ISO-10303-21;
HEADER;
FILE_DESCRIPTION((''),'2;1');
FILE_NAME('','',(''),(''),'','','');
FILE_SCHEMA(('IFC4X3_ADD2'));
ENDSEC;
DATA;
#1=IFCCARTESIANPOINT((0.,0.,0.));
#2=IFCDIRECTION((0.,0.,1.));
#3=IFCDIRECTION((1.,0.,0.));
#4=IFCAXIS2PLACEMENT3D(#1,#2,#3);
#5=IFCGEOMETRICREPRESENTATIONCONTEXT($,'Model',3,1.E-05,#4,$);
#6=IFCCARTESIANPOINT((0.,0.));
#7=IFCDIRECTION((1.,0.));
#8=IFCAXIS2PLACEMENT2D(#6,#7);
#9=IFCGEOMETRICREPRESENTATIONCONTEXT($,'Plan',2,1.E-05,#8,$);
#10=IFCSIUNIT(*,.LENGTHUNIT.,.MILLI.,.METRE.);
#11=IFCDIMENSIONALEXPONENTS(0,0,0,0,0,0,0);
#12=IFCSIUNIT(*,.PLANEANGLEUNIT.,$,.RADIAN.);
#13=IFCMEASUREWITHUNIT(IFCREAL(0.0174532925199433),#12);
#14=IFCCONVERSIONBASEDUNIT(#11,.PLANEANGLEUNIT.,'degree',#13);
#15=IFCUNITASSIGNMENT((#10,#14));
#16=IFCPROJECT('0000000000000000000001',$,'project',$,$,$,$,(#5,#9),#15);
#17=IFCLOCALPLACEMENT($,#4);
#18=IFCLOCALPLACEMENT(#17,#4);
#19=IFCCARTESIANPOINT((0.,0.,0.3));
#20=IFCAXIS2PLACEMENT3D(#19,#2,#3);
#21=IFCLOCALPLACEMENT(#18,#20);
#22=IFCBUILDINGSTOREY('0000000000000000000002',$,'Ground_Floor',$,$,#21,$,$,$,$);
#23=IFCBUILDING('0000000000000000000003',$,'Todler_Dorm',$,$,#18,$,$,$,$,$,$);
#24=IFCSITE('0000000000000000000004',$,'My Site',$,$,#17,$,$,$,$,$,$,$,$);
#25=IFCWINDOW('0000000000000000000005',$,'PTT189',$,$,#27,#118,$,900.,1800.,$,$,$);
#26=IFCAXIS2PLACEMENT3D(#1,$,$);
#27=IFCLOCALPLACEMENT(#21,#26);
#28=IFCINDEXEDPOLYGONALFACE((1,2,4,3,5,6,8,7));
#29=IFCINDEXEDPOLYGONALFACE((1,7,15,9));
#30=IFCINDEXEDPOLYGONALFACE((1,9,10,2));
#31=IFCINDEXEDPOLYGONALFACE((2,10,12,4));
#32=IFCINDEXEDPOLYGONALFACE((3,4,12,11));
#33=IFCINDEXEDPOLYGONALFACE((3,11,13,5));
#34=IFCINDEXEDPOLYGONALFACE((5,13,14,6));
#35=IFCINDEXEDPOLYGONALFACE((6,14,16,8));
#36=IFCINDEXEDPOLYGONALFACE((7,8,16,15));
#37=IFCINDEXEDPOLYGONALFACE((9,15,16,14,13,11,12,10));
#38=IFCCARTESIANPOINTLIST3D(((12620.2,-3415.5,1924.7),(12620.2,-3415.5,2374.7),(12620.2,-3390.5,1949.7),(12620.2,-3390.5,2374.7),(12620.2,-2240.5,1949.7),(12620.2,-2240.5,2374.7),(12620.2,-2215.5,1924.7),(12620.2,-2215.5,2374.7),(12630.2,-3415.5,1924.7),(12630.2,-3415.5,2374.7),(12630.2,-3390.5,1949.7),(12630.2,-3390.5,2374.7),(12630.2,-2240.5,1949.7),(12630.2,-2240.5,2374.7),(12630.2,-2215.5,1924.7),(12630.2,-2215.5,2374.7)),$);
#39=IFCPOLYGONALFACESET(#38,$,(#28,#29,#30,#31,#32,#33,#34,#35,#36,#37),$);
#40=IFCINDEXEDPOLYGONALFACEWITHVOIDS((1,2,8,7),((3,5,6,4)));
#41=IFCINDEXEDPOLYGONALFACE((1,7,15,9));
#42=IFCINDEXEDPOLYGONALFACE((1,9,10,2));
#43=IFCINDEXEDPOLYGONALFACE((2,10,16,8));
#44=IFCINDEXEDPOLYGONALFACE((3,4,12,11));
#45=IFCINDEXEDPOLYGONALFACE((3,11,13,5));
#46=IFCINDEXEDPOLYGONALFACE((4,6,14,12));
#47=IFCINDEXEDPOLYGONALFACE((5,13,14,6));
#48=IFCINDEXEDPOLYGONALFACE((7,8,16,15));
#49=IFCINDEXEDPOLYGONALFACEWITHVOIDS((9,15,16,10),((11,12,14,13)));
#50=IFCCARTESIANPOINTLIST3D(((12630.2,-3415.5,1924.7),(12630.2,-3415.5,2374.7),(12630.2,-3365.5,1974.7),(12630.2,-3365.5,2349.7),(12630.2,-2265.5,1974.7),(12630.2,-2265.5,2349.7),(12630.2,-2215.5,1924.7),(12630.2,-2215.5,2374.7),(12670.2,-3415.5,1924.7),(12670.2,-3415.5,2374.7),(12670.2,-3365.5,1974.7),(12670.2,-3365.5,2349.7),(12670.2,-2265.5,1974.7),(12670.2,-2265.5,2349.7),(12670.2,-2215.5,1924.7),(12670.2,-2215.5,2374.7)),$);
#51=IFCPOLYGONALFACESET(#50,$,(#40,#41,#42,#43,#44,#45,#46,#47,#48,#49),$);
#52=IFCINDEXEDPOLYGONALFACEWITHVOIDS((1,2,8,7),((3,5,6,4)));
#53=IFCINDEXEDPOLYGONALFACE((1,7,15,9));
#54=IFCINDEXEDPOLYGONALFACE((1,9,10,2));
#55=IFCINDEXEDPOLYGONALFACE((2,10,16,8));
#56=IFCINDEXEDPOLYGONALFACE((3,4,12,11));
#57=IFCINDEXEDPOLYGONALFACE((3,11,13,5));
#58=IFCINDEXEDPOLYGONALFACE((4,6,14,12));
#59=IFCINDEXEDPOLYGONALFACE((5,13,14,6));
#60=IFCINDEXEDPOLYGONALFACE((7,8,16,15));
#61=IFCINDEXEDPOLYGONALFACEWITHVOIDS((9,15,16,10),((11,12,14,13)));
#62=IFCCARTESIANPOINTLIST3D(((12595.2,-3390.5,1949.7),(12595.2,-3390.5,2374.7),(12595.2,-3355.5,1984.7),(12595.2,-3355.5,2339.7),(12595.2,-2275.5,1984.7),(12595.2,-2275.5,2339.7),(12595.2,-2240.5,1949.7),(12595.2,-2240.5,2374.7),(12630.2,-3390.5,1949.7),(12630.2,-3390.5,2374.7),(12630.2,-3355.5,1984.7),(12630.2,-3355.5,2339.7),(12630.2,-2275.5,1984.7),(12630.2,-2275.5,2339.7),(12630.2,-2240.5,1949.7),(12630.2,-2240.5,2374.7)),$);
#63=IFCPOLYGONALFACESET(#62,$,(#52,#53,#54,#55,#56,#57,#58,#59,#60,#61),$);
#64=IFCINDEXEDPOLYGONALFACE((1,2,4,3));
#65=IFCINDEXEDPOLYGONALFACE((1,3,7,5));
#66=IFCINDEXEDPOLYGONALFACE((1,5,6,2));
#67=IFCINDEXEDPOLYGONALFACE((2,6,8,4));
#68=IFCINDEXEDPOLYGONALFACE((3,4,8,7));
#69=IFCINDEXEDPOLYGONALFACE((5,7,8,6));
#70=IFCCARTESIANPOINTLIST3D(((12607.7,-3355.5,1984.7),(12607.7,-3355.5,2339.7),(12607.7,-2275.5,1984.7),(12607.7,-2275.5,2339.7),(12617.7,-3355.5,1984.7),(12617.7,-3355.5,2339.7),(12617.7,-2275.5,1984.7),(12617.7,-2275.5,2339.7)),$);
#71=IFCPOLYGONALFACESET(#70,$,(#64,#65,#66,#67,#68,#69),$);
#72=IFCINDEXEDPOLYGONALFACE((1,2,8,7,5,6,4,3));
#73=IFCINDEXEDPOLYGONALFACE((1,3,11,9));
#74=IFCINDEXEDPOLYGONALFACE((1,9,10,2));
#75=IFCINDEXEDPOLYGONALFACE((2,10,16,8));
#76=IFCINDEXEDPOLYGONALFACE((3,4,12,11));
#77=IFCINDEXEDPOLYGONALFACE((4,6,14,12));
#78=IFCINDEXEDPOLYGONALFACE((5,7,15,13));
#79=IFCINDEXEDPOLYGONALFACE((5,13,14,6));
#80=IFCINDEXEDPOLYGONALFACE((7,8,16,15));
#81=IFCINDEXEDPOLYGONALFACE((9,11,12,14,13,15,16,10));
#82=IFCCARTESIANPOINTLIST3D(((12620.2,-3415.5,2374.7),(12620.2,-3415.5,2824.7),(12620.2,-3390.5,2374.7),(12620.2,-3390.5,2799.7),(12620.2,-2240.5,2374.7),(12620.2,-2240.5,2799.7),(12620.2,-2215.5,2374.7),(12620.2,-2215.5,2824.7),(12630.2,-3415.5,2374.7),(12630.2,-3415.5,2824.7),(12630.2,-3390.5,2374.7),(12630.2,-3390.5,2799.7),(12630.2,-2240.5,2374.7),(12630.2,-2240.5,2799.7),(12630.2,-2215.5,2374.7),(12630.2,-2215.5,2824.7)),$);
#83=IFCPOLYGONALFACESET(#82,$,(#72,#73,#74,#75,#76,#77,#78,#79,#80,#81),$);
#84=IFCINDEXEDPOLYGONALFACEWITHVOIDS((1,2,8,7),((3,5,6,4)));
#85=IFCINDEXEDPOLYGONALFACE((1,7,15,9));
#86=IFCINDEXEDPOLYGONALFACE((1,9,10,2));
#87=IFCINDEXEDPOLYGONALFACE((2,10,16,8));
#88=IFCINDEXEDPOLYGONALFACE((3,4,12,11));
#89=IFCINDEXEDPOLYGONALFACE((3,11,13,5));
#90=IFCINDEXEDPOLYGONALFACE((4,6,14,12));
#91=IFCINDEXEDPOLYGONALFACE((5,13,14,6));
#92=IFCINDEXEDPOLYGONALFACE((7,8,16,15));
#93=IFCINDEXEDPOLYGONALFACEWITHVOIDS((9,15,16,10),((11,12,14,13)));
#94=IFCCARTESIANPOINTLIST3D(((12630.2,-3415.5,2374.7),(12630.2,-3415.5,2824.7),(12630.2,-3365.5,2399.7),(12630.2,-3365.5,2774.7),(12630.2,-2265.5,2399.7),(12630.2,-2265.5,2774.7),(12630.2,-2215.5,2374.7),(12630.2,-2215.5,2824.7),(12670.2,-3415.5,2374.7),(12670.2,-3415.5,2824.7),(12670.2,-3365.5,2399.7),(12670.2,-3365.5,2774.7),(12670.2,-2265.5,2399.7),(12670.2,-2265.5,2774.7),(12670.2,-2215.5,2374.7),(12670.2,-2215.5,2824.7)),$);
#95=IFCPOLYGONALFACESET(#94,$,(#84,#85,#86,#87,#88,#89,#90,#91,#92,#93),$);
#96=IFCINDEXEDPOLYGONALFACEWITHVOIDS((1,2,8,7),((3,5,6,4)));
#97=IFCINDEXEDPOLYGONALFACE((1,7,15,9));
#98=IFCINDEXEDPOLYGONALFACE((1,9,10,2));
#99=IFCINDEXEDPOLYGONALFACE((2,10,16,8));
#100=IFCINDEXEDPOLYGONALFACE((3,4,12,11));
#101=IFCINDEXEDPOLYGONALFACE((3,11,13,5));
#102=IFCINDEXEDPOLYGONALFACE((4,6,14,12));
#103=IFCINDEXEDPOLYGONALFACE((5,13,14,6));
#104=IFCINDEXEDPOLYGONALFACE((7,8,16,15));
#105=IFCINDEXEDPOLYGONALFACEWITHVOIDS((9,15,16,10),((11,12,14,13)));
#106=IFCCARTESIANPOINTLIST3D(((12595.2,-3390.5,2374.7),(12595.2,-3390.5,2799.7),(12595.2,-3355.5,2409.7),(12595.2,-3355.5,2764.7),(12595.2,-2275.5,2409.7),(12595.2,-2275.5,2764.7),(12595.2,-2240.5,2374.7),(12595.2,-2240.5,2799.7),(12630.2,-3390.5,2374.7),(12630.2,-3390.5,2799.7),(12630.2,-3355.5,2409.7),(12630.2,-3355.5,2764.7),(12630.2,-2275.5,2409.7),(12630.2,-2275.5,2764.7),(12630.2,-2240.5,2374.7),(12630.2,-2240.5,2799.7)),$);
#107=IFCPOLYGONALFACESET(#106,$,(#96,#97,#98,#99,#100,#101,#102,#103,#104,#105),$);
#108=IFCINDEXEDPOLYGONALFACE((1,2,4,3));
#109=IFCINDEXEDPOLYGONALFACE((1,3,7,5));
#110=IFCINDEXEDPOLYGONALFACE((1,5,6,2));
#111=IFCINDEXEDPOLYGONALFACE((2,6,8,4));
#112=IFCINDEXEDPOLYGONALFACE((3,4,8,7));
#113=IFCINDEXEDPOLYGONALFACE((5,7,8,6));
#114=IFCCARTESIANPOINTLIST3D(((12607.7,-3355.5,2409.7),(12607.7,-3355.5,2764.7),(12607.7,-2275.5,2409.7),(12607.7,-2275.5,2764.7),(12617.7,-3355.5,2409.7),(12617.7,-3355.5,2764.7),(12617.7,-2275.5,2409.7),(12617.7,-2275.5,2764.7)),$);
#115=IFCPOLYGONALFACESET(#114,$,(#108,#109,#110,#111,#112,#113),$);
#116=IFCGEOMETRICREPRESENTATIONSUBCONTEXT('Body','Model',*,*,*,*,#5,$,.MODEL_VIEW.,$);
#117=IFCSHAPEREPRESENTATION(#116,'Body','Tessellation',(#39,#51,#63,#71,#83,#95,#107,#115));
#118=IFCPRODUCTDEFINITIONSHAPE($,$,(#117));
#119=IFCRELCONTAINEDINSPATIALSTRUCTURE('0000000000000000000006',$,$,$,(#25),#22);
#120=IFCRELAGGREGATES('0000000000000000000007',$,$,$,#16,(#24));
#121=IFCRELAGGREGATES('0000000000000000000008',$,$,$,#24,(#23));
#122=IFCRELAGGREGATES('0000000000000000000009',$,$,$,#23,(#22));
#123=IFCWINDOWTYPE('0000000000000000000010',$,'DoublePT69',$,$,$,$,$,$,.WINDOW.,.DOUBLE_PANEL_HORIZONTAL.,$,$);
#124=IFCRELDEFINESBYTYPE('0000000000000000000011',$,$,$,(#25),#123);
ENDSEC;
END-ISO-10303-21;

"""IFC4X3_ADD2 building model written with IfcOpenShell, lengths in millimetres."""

from ifc_helpers import new_model, entity, si_unit, converted_unit, frame, origin_with_axes, origin_2d_with_axis, place, context, subcontext, project, spatial, line, indexed_curve, outline, extrude, shape, source, transform, mapped, type_object, type_shapes, element, save


model = new_model("IFC4X3_ADD2")

# Units and contexts
model_context = context("Model", 3, precision=1e-05, world=origin_with_axes())
plan_context = context("Plan", 2, precision=1e-05, world=origin_2d_with_axis())
body_context_1 = subcontext(model_context, "Body", "Model", "MODEL_VIEW")
body_context_2 = subcontext(plan_context, "Body", "Plan", "PLAN_VIEW")
ifc_project = project(units=[si_unit("LENGTHUNIT", "METRE", prefix="MILLI"), converted_unit("PLANEANGLEUNIT", "degree", entity("IfcReal", 0.0174532925199433), si_unit("PLANEANGLEUNIT", "RADIAN"), dimensions=[0, 0, 0, 0, 0, 0, 0])], contexts=[model_context, plan_context])

# Site, building, storey
site_placement = place(None, origin_with_axes())
site = spatial("IfcSite", under=ifc_project, at=site_placement, Name="My Site")
building_placement = place(site_placement, origin_with_axes())
building = spatial("IfcBuilding", under=site, at=building_placement, Name="Todler_Dorm")
storey_placement = place(building_placement, frame((0.0, 0.0, 0.3), z_axis=(0.0, 0.0, 1.0), x_axis=(1.0, 0.0, 0.0)))
storey = spatial("IfcBuildingStorey", under=building, at=storey_placement, Name="Ground_Floor")

# Shared definitions
window_type_1 = type_object("IfcWindowType", Name="DoublePT69", PartitioningType="DOUBLE_PANEL_HORIZONTAL", PredefinedType="WINDOW")
shared_shape_1 = source(origin_with_axes(), body_context_1, "Body", "SweptSolid", [
    extrude(outline(indexed_curve([(1200.0, 450.0), (1200.0, 0.0), (0.0, 0.0), (0.0, 450.0), (25.0, 450.0), (25.0, 25.0), (1175.0, 25.0), (1175.0, 450.0)], segments=[line(1, 2, 3, 4, 5, 6, 7, 8, 1)])), frame((0.0, 90.0, 0.0), z_axis=(0.0, -1.0, 0.0), x_axis=(1.0, 0.0, 0.0)), (0.0, 0.0, -1.0), 10.0),
    extrude(outline(indexed_curve([(0.0, 0.0), (1200.0, 0.0), (1200.0, 450.0), (0.0, 450.0)], segments=[line(1, 2, 3, 4, 1)]), holes=[indexed_curve([(50.0, 50.0), (1150.0, 50.0), (1150.0, 425.0), (50.0, 425.0)], segments=[line(1, 2, 3, 4, 1)])]), frame((0.0, 50.0, 0.0), z_axis=(0.0, -1.0, 0.0), x_axis=(1.0, 0.0, 0.0)), (0.0, 0.0, -1.0), 40.0),
    extrude(outline(indexed_curve([(0.0, 0.0), (1150.0, 0.0), (1150.0, 425.0), (0.0, 425.0)], segments=[line(1, 2, 3, 4, 1)]), holes=[indexed_curve([(35.0, 35.0), (1115.0, 35.0), (1115.0, 390.0), (35.0, 390.0)], segments=[line(1, 2, 3, 4, 1)])]), frame((25.0, 90.0, 25.0), z_axis=(0.0, -1.0, 0.0), x_axis=(1.0, 0.0, 0.0)), (0.0, 0.0, -1.0), 35.0),
    extrude(outline(indexed_curve([(35.0, 35.0), (1115.0, 35.0), (1115.0, 390.0), (35.0, 390.0)], segments=[line(1, 2, 3, 4, 1)])), frame((25.0, 102.5, 25.0), z_axis=(0.0, -1.0, 0.0), x_axis=(1.0, 0.0, 0.0)), (0.0, 0.0, -1.0), 10.0),
    extrude(outline(indexed_curve([(0.0, 0.0), (0.0, 450.0), (1200.0, 450.0), (1200.0, 0.0), (1175.0, 0.0), (1175.0, 425.0), (25.0, 425.0), (25.0, 0.0)], segments=[line(1, 2, 3, 4, 5, 6, 7, 8, 1)])), frame((0.0, 90.0, 450.0), z_axis=(0.0, -1.0, 0.0), x_axis=(1.0, 0.0, 0.0)), (0.0, 0.0, -1.0), 10.0),
    extrude(outline(indexed_curve([(0.0, 0.0), (1200.0, 0.0), (1200.0, 450.0), (0.0, 450.0)], segments=[line(1, 2, 3, 4, 1)]), holes=[indexed_curve([(50.0, 25.0), (1150.0, 25.0), (1150.0, 400.0), (50.0, 400.0)], segments=[line(1, 2, 3, 4, 1)])]), frame((0.0, 50.0, 450.0), z_axis=(0.0, -1.0, 0.0), x_axis=(1.0, 0.0, 0.0)), (0.0, 0.0, -1.0), 40.0),
    extrude(outline(indexed_curve([(0.0, 0.0), (1150.0, 0.0), (1150.0, 425.0), (0.0, 425.0)], segments=[line(1, 2, 3, 4, 1)]), holes=[indexed_curve([(35.0, 35.0), (1115.0, 35.0), (1115.0, 390.0), (35.0, 390.0)], segments=[line(1, 2, 3, 4, 1)])]), frame((25.0, 90.0, 450.0), z_axis=(0.0, -1.0, 0.0), x_axis=(1.0, 0.0, 0.0)), (0.0, 0.0, -1.0), 35.0),
    extrude(outline(indexed_curve([(35.0, 35.0), (1115.0, 35.0), (1115.0, 390.0), (35.0, 390.0)], segments=[line(1, 2, 3, 4, 1)])), frame((25.0, 102.5, 450.0), z_axis=(0.0, -1.0, 0.0), x_axis=(1.0, 0.0, 0.0)), (0.0, 0.0, -1.0), 10.0),
])
shared_shape_2 = source(origin_with_axes(), body_context_2, "Body", "Curve2D", [
    entity("IfcIndexedPolyCurve", entity("IfcCartesianPointList2D", [[50.0, 50.0], [1150.0, 50.0]])),
    entity("IfcIndexedPolyCurve", entity("IfcCartesianPointList2D", [[0.0, 100.0], [25.0, 100.0], [25.0, 90.0], [50.0, 90.0], [50.0, 50.0], [0.0, 50.0]]), [entity("IfcLineIndex", [1, 2, 3, 4, 5, 6, 1])]),
    entity("IfcIndexedPolyCurve", entity("IfcCartesianPointList2D", [[1200.0, 100.0], [1175.0, 100.0], [1175.0, 90.0], [1150.0, 90.0], [1150.0, 50.0], [1200.0, 50.0]]), [entity("IfcLineIndex", [1, 2, 3, 4, 5, 6, 1])]),
    entity("IfcIndexedPolyCurve", entity("IfcCartesianPointList2D", [[25.0, 90.0], [60.0, 90.0], [60.0, 125.0], [25.0, 125.0]]), [entity("IfcLineIndex", [1, 2, 3, 4, 1])]),
    entity("IfcIndexedPolyCurve", entity("IfcCartesianPointList2D", [[1175.0, 90.0], [1140.0, 90.0], [1140.0, 125.0], [1175.0, 125.0]]), [entity("IfcLineIndex", [1, 2, 3, 4, 1])]),
    entity("IfcIndexedPolyCurve", entity("IfcCartesianPointList2D", [[60.0, 90.0], [1140.0, 90.0]])),
    entity("IfcIndexedPolyCurve", entity("IfcCartesianPointList2D", [[60.0, 125.0], [1140.0, 125.0]])),
    entity("IfcIndexedPolyCurve", entity("IfcCartesianPointList2D", [[60.0, 107.5], [1140.0, 107.5]])),
])
type_shapes(window_type_1, [shared_shape_1, shared_shape_2])

# Window
window_1_placement = place(storey_placement, frame((12720.2, -3415.5, 1924.7), z_axis=(0.0, 0.0, 1.0), x_axis=(0.0, 1.0, 0.0)))
element("IfcWindow", 1, at=window_1_placement, inside=storey, type_object=window_type_1, Name="PTT189", OverallHeight=900.0, OverallWidth=1800.0, shapes=[
    shape(body_context_1, "Body", "MappedRepresentation", [mapped(shared_shape_1, transform((0.0, 0.0, 0.0), x_axis=(1.0, 0.0, 0.0), y_axis=(0.0, 1.0, 0.0), z_axis=(0.0, 0.0, 1.0), scale=1.0))]),
    shape(body_context_2, "Body", "MappedRepresentation", [mapped(shared_shape_2, transform((0.0, 0.0, 0.0), x_axis=(1.0, 0.0, 0.0), y_axis=(0.0, 1.0, 0.0), z_axis=(0.0, 0.0, 1.0), scale=1.0))]),
])

save(model, "model.ifc")
